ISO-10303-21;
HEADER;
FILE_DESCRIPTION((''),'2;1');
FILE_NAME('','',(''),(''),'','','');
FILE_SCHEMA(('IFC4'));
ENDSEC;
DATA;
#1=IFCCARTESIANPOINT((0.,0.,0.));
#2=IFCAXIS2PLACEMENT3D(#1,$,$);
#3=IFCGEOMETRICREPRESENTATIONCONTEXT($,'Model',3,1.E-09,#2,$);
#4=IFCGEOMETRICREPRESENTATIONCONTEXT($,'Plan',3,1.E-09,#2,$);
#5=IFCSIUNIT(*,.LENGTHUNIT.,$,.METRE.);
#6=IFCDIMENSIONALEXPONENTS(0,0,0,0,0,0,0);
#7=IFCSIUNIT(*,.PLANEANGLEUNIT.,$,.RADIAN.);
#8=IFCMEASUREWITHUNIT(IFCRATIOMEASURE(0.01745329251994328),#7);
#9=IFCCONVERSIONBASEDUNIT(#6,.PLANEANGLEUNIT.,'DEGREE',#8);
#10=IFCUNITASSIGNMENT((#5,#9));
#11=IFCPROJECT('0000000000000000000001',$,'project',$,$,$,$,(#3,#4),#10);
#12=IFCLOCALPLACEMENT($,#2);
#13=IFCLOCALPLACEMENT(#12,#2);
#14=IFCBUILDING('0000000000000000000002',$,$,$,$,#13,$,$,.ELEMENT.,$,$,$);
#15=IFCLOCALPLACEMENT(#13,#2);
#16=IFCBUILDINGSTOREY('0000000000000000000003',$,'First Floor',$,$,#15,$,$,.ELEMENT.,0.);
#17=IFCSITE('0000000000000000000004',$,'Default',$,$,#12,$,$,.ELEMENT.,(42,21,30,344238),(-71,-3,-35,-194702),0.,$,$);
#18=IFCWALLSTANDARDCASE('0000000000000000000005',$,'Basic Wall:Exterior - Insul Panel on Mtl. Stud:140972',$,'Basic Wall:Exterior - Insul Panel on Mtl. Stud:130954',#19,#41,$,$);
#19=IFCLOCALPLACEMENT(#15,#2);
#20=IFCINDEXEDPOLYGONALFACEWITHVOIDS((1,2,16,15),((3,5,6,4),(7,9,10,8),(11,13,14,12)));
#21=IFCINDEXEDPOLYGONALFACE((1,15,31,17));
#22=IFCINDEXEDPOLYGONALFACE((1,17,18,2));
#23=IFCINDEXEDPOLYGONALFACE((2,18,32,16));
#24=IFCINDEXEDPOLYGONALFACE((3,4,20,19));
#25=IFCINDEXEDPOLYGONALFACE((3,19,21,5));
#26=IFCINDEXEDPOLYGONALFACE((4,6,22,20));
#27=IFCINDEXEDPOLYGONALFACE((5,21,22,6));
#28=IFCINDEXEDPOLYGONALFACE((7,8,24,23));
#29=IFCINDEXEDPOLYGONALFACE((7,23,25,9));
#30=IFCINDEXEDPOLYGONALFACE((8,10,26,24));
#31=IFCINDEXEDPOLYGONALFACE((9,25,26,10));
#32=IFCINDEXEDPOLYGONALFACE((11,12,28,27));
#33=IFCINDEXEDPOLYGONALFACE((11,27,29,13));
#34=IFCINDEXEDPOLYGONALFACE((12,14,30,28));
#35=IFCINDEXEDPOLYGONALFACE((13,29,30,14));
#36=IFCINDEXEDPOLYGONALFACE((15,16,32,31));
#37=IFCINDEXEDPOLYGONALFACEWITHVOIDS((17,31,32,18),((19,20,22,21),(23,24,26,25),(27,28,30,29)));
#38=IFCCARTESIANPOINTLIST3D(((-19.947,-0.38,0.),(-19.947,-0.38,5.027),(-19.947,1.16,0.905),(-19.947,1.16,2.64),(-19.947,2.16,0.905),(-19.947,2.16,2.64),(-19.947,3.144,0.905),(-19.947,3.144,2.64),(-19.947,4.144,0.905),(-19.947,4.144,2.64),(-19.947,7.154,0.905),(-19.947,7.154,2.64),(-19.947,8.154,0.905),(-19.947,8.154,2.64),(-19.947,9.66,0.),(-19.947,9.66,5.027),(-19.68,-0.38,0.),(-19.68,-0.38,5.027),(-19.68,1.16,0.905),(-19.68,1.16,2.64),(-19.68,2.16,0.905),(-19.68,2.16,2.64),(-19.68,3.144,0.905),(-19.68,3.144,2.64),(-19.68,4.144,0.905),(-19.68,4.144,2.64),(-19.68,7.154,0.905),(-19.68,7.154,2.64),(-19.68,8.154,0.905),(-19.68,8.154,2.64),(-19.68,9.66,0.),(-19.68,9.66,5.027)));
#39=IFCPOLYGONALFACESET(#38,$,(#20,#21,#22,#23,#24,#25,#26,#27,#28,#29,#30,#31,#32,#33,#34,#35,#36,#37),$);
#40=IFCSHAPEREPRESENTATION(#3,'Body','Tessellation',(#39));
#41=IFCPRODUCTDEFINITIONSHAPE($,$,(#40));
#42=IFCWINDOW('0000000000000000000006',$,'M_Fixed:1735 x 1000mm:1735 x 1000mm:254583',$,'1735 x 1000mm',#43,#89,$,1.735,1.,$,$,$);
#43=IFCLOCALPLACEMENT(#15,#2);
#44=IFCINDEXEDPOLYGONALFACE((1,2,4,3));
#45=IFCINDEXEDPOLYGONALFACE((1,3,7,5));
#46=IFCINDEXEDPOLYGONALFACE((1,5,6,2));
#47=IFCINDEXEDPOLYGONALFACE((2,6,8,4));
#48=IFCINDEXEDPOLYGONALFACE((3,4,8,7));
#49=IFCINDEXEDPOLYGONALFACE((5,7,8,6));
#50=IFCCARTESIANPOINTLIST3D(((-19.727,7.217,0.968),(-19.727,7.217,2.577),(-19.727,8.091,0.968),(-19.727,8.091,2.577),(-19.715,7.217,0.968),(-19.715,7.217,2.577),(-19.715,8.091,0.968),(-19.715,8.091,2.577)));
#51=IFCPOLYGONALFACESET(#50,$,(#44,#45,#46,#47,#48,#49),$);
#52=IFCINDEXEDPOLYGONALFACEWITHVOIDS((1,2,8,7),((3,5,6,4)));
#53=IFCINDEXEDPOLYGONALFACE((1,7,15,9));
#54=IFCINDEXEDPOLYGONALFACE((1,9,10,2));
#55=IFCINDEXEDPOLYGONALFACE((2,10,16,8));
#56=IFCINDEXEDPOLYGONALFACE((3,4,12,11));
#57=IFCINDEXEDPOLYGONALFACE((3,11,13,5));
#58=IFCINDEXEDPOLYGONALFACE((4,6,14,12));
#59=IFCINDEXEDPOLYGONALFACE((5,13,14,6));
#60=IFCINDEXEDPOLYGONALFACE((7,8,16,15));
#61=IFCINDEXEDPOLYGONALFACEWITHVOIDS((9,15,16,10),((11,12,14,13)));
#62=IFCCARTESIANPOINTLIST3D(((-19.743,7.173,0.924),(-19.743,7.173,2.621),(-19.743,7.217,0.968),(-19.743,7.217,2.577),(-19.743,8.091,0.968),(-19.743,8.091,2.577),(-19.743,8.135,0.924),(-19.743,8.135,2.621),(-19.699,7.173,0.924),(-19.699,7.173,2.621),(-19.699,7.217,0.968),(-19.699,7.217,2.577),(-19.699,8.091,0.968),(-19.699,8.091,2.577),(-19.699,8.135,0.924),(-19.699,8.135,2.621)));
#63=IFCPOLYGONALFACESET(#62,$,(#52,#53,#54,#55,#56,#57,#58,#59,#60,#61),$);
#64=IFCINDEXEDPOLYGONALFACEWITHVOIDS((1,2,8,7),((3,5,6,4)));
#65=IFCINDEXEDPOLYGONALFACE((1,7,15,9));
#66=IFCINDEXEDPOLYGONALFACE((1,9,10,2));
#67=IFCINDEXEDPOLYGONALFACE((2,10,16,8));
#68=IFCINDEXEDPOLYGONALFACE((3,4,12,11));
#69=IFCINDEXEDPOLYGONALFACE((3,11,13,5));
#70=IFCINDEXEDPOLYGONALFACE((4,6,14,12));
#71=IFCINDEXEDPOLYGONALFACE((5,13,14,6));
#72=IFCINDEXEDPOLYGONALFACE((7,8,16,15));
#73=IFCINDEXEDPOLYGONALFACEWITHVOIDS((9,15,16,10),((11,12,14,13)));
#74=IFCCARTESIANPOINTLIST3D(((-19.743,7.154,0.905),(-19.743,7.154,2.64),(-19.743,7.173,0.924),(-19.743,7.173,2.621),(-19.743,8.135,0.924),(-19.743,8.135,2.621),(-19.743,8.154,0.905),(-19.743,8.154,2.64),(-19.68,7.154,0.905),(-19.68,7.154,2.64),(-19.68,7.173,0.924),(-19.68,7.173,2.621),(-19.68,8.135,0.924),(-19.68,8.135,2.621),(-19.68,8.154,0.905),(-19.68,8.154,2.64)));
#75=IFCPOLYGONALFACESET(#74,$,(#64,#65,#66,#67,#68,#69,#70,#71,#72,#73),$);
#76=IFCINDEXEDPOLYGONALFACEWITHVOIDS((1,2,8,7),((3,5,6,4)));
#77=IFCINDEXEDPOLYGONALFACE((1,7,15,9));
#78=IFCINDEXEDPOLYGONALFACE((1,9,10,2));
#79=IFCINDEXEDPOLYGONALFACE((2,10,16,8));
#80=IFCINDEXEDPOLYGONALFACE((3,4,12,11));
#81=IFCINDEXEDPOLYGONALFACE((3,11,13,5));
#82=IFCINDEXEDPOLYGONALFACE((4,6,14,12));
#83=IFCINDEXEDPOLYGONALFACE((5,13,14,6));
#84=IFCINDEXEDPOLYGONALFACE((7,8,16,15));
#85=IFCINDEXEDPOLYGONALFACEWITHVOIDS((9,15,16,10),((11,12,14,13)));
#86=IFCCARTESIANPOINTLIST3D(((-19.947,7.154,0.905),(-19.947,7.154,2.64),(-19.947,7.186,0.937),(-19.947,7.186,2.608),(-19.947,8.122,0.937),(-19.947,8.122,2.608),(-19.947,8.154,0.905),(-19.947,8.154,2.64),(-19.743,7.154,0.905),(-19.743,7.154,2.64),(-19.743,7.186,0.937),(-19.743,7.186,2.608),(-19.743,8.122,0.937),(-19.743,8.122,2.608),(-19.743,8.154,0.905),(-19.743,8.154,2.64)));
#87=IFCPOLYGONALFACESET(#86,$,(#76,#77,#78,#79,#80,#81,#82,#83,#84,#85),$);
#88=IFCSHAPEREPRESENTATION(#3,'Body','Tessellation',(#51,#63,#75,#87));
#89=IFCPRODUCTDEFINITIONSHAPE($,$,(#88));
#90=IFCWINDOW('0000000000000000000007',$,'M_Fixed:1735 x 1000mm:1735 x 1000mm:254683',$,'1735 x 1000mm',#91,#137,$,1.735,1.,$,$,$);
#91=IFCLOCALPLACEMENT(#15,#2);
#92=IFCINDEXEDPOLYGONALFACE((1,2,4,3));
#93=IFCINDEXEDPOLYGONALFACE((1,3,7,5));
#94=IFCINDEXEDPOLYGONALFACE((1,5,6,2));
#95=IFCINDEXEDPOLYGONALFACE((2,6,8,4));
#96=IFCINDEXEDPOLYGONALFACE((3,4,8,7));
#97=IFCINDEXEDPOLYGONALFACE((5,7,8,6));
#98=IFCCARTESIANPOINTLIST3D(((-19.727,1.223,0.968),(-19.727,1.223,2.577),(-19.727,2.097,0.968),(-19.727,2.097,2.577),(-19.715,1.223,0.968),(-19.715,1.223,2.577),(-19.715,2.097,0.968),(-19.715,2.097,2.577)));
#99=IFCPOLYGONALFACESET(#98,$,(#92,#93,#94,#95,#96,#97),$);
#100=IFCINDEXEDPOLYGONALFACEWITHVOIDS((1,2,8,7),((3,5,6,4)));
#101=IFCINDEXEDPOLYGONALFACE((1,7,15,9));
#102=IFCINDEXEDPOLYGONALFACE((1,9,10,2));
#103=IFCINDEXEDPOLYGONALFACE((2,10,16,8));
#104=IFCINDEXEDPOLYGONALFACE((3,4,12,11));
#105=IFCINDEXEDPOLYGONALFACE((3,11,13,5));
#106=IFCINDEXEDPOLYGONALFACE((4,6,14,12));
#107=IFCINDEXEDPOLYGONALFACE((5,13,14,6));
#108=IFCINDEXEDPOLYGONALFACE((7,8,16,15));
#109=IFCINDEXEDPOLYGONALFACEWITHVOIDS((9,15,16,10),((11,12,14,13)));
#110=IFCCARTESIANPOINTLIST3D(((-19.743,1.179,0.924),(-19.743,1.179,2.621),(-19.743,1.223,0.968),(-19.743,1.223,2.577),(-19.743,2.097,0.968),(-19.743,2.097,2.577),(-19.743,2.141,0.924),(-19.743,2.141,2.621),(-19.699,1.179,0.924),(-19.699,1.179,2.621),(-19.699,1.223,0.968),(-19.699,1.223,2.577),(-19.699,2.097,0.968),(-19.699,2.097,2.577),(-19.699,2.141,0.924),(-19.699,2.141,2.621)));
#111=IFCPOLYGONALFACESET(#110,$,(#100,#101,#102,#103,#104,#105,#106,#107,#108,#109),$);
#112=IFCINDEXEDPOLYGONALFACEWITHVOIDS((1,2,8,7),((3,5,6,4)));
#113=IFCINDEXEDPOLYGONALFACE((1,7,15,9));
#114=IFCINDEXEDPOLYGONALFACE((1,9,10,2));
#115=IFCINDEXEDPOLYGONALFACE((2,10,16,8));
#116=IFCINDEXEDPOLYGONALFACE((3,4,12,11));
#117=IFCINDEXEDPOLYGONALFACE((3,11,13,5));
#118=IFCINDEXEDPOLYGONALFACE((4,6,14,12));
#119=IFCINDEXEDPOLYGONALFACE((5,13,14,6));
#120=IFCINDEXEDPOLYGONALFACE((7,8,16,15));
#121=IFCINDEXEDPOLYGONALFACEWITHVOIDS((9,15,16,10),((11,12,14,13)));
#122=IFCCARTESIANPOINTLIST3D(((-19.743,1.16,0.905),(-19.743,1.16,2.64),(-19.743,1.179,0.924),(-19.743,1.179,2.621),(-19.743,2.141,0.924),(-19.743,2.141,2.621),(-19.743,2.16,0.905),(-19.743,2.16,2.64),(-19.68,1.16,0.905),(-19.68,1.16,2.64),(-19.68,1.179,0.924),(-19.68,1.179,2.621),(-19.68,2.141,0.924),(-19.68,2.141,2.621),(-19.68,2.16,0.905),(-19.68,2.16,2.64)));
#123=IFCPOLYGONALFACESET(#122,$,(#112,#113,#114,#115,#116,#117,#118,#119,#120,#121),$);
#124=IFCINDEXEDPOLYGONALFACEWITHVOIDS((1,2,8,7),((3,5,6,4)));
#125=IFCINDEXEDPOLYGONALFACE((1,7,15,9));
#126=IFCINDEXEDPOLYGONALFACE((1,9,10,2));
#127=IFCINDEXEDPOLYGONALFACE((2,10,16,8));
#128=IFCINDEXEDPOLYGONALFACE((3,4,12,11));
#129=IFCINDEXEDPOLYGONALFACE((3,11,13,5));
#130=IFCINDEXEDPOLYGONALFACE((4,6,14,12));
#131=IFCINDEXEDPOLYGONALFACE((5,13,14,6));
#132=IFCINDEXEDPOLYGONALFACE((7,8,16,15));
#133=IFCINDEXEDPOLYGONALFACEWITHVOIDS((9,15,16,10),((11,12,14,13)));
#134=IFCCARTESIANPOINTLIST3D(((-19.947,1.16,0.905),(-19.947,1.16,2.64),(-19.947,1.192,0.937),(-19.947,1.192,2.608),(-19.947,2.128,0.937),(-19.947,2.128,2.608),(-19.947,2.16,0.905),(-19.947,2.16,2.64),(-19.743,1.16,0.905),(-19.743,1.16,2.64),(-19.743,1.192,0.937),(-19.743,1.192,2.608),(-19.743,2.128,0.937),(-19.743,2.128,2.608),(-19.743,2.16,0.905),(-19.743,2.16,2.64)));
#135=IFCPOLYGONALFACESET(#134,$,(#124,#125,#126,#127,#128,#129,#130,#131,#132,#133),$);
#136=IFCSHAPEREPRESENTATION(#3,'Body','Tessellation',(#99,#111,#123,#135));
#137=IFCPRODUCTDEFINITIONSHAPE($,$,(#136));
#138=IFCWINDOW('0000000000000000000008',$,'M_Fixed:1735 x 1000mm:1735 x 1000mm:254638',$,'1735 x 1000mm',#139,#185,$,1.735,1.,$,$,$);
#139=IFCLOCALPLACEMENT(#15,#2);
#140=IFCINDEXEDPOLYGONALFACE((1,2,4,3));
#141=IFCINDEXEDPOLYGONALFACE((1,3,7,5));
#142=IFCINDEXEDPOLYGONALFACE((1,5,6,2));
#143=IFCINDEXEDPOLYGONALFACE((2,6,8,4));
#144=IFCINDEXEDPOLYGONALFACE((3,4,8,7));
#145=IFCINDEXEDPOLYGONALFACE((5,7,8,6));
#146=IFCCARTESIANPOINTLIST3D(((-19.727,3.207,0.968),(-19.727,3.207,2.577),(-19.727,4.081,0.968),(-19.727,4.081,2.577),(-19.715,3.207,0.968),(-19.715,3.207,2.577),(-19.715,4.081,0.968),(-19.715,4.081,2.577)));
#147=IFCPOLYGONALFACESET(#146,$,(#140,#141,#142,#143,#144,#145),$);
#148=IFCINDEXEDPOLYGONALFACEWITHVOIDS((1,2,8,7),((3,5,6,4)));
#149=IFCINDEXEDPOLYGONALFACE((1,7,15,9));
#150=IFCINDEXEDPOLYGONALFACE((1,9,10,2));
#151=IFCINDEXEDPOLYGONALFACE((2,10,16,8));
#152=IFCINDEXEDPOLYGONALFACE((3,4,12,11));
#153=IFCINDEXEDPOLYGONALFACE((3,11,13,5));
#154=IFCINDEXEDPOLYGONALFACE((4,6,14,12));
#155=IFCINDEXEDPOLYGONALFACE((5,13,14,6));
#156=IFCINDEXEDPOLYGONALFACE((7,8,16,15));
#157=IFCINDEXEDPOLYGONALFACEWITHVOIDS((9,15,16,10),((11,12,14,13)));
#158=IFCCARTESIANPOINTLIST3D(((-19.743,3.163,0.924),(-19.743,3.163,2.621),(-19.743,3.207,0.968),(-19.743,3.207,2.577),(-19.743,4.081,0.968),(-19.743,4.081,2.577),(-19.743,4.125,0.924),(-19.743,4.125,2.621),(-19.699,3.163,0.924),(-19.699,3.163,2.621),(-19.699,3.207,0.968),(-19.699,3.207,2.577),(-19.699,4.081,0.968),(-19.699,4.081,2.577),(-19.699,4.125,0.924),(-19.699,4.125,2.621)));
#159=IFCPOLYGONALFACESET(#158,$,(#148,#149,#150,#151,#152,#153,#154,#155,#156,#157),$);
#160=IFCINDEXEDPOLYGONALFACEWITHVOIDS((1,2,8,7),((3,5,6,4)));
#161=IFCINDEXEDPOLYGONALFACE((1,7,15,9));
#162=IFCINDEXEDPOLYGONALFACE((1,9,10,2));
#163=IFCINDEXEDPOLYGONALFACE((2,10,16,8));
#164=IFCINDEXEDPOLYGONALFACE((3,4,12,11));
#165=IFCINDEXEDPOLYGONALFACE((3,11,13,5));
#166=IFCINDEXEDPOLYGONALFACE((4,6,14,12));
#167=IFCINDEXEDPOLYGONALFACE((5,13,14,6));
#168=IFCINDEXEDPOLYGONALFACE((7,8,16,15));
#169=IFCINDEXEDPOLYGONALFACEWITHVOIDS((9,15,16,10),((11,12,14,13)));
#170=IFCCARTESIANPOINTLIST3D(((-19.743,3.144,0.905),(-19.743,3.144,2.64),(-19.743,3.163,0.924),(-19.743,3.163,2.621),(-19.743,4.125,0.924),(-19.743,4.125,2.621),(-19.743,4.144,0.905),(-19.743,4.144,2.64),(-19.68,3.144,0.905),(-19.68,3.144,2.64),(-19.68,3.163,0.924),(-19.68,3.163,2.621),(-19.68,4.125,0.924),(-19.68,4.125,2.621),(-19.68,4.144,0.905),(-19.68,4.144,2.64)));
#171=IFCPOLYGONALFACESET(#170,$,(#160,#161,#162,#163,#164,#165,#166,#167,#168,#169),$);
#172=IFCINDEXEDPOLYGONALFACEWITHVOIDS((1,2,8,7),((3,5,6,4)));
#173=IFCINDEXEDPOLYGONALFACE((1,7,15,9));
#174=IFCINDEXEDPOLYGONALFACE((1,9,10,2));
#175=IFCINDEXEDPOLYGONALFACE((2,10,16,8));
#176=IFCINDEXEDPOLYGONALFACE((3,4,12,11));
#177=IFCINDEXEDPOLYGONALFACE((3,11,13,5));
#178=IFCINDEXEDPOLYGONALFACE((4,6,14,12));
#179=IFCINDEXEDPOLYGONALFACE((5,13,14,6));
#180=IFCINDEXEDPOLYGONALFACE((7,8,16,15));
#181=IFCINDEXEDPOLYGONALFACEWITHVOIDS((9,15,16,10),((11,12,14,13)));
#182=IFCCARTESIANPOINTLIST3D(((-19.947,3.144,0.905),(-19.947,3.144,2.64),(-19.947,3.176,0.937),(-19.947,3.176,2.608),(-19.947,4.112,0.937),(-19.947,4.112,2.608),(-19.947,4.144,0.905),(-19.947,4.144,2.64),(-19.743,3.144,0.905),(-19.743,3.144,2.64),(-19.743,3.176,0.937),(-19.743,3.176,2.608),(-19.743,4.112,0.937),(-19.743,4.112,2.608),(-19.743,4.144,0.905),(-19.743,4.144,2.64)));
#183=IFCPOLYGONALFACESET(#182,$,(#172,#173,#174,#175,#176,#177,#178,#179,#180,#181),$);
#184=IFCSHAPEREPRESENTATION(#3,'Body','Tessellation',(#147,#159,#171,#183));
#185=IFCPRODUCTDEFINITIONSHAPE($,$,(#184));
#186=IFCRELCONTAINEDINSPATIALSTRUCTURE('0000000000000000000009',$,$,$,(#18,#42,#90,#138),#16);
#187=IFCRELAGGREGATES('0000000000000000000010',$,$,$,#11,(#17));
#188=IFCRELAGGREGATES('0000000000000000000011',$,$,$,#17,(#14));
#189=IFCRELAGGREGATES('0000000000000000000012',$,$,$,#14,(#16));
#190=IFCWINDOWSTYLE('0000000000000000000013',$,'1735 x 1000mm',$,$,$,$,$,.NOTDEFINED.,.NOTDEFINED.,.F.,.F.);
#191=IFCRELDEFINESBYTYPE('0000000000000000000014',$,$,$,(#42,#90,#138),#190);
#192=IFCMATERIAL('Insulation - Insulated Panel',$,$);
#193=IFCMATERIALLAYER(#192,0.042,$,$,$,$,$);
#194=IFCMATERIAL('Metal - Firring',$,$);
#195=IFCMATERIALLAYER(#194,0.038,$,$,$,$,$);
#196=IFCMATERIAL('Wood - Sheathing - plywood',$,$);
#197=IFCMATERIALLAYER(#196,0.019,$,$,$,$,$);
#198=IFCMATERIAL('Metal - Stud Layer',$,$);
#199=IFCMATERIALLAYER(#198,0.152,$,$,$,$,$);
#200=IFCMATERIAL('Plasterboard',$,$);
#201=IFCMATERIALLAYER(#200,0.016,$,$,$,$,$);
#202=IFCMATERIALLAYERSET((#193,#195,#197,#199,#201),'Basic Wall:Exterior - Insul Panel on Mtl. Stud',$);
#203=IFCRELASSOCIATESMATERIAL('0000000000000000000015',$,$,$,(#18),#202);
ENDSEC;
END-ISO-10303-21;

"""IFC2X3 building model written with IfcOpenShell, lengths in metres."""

from ifc_helpers import new_model, entity, si_unit, converted_unit, frame, frame_2d, origin, origin_2d_with_axis, place, context, project, spatial, polyline, rectangle, outline, extrude, source, transform, mapped, material, layer, layer_set, layer_usage, type_object, type_shapes, element, fill, save


model = new_model("IFC2X3")

# Units and contexts
model_context = context("Model", 3, precision=1e-09, world=origin())
plan_context = context("Plan", 3, precision=1e-09, world=origin())
ifc_project = project(units=[si_unit("LENGTHUNIT", "METRE"), converted_unit("PLANEANGLEUNIT", "DEGREE", entity("IfcRatioMeasure", 0.01745329251994328), si_unit("PLANEANGLEUNIT", "RADIAN"), dimensions=[0, 0, 0, 0, 0, 0, 0])], contexts=[model_context, plan_context])

# Site, building, storey
site_placement = place(None, origin())
site = spatial("IfcSite", under=ifc_project, at=site_placement, Name="Default", CompositionType="ELEMENT", RefLatitude=(42, 21, 30, 344238), RefLongitude=(-71, -3, -35, -194702), RefElevation=0.0)
building_placement = place(site_placement, origin())
building = spatial("IfcBuilding", under=site, at=building_placement, CompositionType="ELEMENT")
storey_placement = place(building_placement, origin())
storey = spatial("IfcBuildingStorey", under=building, at=storey_placement, Name="First Floor", CompositionType="ELEMENT", Elevation=0.0)

# Shared definitions
ifc_material_1 = material(Name="Insulation - Insulated Panel")
ifc_layer_1 = layer(ifc_material_1, 0.042)
ifc_material_2 = material(Name="Metal - Firring")
ifc_layer_2 = layer(ifc_material_2, 0.038)
ifc_material_3 = material(Name="Wood - Sheathing - plywood")
ifc_layer_3 = layer(ifc_material_3, 0.019)
ifc_material_4 = material(Name="Metal - Stud Layer")
ifc_layer_4 = layer(ifc_material_4, 0.152)
ifc_material_5 = material(Name="Plasterboard")
ifc_layer_5 = layer(ifc_material_5, 0.016)
ifc_layer_set_1 = layer_set([ifc_layer_1, ifc_layer_2, ifc_layer_3, ifc_layer_4, ifc_layer_5], Name="Basic Wall:Exterior - Insul Panel on Mtl. Stud")
ifc_layer_usage_1 = layer_usage(ifc_layer_set_1, "AXIS2", "NEGATIVE", 0.1335)

# Wall, openings, windows
wall_1_placement = place(storey_placement, frame((-19.8135, 9.66, 0.0), z_axis=(0.0, 0.0, 1.0), x_axis=(0.0, -1.0, 0.0)))
wall_1 = element("IfcWallStandardCase", 1, at=wall_1_placement, inside=storey, material=ifc_layer_usage_1, Name="Basic Wall:Exterior - Insul Panel on Mtl. Stud:140972", ObjectType="Basic Wall:Exterior - Insul Panel on Mtl. Stud:130954", context=model_context, shape_type="SweptSolid", body=[
    extrude(rectangle(XDim=10.04, YDim=0.267, at=frame_2d((5.02, 0.0), x_axis=(-1.0, 0.0))), origin(), (0.0, 0.0, 1.0), 5.027),
])
opening_1_placement = place(wall_1_placement, frame((5.516, -0.1335, 0.905)))
opening_1 = element("IfcOpeningElement", 2, at=opening_1_placement, cuts=wall_1, ObjectType="Opening", context=model_context, shape_type="SweptSolid", body=[
    extrude(rectangle(XDim=1.735, YDim=1.0, at=frame_2d((0.8675, 0.5), x_axis=(1.0, 0.0))), frame((0.0, 0.0, 0.0), z_axis=(0.0, 1.0, 0.0), x_axis=(0.0, 0.0, 1.0)), (0.0, 0.0, 1.0), 0.267),
])
opening_2_placement = place(wall_1_placement, frame((1.506, -0.1335, 0.905)))
opening_2 = element("IfcOpeningElement", 3, at=opening_2_placement, cuts=wall_1, ObjectType="Opening", context=model_context, shape_type="SweptSolid", body=[
    extrude(rectangle(XDim=1.735, YDim=1.0, at=frame_2d((0.8675, 0.5), x_axis=(1.0, 0.0))), frame((0.0, 0.0, 0.0), z_axis=(0.0, 1.0, 0.0), x_axis=(0.0, 0.0, 1.0)), (0.0, 0.0, 1.0), 0.267),
])
opening_3_placement = place(wall_1_placement, frame((7.5, -0.1335, 0.905)))
opening_3 = element("IfcOpeningElement", 4, at=opening_3_placement, cuts=wall_1, ObjectType="Opening", context=model_context, shape_type="SweptSolid", body=[
    extrude(rectangle(XDim=1.735, YDim=1.0, at=frame_2d((0.8675, 0.5), x_axis=(1.0, 0.0))), frame((0.0, 0.0, 0.0), z_axis=(0.0, 1.0, 0.0), x_axis=(0.0, 0.0, 1.0)), (0.0, 0.0, 1.0), 0.267),
])
window_style = type_object("IfcWindowStyle", Name="1735 x 1000mm", ConstructionType="NOTDEFINED", OperationType="NOTDEFINED", ParameterTakesPrecedence=False, Sizeable=False)
shared_shape_1 = source(origin(), model_context, "Body", "SweptSolid", [
    extrude(rectangle(XDim=0.012, YDim=0.874, at=origin_2d_with_axis()), frame((0.5, 0.226, 0.063), z_axis=(0.0, 0.0, 1.0), x_axis=(0.0, -1.0, 0.0)), (0.0, 0.0, 1.0), 1.609),
    extrude(outline(polyline([(-0.481, -0.8485), (0.481, -0.8485), (0.481, 0.8485), (-0.481, 0.8485), (-0.481, -0.8485)]), holes=[polyline([(-0.437, -0.8045), (-0.437, 0.8045), (0.437, 0.8045), (0.437, -0.8045), (-0.437, -0.8045)])]), frame((0.5, 0.204, 0.8675), z_axis=(0.0, 1.0, 0.0), x_axis=(1.0, 0.0, 0.0)), (0.0, 0.0, 1.0), 0.044),
    extrude(outline(polyline([(-0.5, -0.8675), (0.5, -0.8675), (0.5, 0.8675), (-0.5, 0.8675), (-0.5, -0.8675)]), holes=[polyline([(-0.481, -0.8485), (-0.481, 0.8485), (0.481, 0.8485), (0.481, -0.8485), (-0.481, -0.8485)])]), frame((0.5, 0.204, 0.8675), z_axis=(0.0, 1.0, 0.0), x_axis=(1.0, 0.0, 0.0)), (0.0, 0.0, 1.0), 0.063),
    extrude(outline(polyline([(-0.5, -0.8675), (0.5, -0.8675), (0.5, 0.8675), (-0.5, 0.8675), (-0.5, -0.8675)]), holes=[polyline([(-0.468, -0.8355), (-0.468, 0.8355), (0.468, 0.8355), (0.468, -0.8355), (-0.468, -0.8355)])]), frame((0.5, 0.0, 0.8675), z_axis=(0.0, 1.0, 0.0), x_axis=(1.0, 0.0, 0.0)), (0.0, 0.0, 1.0), 0.204),
])
type_shapes(window_style, [shared_shape_1])
window_1_placement = place(opening_2_placement, origin())
window_1 = element("IfcWindow", 5, at=window_1_placement, inside=storey, type_object=window_style, Name="M_Fixed:1735 x 1000mm:1735 x 1000mm:254583", ObjectType="1735 x 1000mm", OverallHeight=1.735, OverallWidth=1.0, context=model_context, shape_type="MappedRepresentation", body=[
    mapped(shared_shape_1, transform((0.0, 0.0, 0.0), scale=1.0)),
])
fill(opening_2, window_1)
window_2_placement = place(opening_3_placement, origin())
window_2 = element("IfcWindow", 6, at=window_2_placement, inside=storey, type_object=window_style, Name="M_Fixed:1735 x 1000mm:1735 x 1000mm:254683", ObjectType="1735 x 1000mm", OverallHeight=1.735, OverallWidth=1.0, context=model_context, shape_type="MappedRepresentation", body=[
    mapped(shared_shape_1, transform((0.0, 0.0, 0.0), scale=1.0)),
])
fill(opening_3, window_2)
window_3_placement = place(opening_1_placement, origin())
window_3 = element("IfcWindow", 7, at=window_3_placement, inside=storey, type_object=window_style, Name="M_Fixed:1735 x 1000mm:1735 x 1000mm:254638", ObjectType="1735 x 1000mm", OverallHeight=1.735, OverallWidth=1.0, context=model_context, shape_type="MappedRepresentation", body=[
    mapped(shared_shape_1, transform((0.0, 0.0, 0.0), scale=1.0)),
])
fill(opening_1, window_3)

save(model, "model.ifc")
